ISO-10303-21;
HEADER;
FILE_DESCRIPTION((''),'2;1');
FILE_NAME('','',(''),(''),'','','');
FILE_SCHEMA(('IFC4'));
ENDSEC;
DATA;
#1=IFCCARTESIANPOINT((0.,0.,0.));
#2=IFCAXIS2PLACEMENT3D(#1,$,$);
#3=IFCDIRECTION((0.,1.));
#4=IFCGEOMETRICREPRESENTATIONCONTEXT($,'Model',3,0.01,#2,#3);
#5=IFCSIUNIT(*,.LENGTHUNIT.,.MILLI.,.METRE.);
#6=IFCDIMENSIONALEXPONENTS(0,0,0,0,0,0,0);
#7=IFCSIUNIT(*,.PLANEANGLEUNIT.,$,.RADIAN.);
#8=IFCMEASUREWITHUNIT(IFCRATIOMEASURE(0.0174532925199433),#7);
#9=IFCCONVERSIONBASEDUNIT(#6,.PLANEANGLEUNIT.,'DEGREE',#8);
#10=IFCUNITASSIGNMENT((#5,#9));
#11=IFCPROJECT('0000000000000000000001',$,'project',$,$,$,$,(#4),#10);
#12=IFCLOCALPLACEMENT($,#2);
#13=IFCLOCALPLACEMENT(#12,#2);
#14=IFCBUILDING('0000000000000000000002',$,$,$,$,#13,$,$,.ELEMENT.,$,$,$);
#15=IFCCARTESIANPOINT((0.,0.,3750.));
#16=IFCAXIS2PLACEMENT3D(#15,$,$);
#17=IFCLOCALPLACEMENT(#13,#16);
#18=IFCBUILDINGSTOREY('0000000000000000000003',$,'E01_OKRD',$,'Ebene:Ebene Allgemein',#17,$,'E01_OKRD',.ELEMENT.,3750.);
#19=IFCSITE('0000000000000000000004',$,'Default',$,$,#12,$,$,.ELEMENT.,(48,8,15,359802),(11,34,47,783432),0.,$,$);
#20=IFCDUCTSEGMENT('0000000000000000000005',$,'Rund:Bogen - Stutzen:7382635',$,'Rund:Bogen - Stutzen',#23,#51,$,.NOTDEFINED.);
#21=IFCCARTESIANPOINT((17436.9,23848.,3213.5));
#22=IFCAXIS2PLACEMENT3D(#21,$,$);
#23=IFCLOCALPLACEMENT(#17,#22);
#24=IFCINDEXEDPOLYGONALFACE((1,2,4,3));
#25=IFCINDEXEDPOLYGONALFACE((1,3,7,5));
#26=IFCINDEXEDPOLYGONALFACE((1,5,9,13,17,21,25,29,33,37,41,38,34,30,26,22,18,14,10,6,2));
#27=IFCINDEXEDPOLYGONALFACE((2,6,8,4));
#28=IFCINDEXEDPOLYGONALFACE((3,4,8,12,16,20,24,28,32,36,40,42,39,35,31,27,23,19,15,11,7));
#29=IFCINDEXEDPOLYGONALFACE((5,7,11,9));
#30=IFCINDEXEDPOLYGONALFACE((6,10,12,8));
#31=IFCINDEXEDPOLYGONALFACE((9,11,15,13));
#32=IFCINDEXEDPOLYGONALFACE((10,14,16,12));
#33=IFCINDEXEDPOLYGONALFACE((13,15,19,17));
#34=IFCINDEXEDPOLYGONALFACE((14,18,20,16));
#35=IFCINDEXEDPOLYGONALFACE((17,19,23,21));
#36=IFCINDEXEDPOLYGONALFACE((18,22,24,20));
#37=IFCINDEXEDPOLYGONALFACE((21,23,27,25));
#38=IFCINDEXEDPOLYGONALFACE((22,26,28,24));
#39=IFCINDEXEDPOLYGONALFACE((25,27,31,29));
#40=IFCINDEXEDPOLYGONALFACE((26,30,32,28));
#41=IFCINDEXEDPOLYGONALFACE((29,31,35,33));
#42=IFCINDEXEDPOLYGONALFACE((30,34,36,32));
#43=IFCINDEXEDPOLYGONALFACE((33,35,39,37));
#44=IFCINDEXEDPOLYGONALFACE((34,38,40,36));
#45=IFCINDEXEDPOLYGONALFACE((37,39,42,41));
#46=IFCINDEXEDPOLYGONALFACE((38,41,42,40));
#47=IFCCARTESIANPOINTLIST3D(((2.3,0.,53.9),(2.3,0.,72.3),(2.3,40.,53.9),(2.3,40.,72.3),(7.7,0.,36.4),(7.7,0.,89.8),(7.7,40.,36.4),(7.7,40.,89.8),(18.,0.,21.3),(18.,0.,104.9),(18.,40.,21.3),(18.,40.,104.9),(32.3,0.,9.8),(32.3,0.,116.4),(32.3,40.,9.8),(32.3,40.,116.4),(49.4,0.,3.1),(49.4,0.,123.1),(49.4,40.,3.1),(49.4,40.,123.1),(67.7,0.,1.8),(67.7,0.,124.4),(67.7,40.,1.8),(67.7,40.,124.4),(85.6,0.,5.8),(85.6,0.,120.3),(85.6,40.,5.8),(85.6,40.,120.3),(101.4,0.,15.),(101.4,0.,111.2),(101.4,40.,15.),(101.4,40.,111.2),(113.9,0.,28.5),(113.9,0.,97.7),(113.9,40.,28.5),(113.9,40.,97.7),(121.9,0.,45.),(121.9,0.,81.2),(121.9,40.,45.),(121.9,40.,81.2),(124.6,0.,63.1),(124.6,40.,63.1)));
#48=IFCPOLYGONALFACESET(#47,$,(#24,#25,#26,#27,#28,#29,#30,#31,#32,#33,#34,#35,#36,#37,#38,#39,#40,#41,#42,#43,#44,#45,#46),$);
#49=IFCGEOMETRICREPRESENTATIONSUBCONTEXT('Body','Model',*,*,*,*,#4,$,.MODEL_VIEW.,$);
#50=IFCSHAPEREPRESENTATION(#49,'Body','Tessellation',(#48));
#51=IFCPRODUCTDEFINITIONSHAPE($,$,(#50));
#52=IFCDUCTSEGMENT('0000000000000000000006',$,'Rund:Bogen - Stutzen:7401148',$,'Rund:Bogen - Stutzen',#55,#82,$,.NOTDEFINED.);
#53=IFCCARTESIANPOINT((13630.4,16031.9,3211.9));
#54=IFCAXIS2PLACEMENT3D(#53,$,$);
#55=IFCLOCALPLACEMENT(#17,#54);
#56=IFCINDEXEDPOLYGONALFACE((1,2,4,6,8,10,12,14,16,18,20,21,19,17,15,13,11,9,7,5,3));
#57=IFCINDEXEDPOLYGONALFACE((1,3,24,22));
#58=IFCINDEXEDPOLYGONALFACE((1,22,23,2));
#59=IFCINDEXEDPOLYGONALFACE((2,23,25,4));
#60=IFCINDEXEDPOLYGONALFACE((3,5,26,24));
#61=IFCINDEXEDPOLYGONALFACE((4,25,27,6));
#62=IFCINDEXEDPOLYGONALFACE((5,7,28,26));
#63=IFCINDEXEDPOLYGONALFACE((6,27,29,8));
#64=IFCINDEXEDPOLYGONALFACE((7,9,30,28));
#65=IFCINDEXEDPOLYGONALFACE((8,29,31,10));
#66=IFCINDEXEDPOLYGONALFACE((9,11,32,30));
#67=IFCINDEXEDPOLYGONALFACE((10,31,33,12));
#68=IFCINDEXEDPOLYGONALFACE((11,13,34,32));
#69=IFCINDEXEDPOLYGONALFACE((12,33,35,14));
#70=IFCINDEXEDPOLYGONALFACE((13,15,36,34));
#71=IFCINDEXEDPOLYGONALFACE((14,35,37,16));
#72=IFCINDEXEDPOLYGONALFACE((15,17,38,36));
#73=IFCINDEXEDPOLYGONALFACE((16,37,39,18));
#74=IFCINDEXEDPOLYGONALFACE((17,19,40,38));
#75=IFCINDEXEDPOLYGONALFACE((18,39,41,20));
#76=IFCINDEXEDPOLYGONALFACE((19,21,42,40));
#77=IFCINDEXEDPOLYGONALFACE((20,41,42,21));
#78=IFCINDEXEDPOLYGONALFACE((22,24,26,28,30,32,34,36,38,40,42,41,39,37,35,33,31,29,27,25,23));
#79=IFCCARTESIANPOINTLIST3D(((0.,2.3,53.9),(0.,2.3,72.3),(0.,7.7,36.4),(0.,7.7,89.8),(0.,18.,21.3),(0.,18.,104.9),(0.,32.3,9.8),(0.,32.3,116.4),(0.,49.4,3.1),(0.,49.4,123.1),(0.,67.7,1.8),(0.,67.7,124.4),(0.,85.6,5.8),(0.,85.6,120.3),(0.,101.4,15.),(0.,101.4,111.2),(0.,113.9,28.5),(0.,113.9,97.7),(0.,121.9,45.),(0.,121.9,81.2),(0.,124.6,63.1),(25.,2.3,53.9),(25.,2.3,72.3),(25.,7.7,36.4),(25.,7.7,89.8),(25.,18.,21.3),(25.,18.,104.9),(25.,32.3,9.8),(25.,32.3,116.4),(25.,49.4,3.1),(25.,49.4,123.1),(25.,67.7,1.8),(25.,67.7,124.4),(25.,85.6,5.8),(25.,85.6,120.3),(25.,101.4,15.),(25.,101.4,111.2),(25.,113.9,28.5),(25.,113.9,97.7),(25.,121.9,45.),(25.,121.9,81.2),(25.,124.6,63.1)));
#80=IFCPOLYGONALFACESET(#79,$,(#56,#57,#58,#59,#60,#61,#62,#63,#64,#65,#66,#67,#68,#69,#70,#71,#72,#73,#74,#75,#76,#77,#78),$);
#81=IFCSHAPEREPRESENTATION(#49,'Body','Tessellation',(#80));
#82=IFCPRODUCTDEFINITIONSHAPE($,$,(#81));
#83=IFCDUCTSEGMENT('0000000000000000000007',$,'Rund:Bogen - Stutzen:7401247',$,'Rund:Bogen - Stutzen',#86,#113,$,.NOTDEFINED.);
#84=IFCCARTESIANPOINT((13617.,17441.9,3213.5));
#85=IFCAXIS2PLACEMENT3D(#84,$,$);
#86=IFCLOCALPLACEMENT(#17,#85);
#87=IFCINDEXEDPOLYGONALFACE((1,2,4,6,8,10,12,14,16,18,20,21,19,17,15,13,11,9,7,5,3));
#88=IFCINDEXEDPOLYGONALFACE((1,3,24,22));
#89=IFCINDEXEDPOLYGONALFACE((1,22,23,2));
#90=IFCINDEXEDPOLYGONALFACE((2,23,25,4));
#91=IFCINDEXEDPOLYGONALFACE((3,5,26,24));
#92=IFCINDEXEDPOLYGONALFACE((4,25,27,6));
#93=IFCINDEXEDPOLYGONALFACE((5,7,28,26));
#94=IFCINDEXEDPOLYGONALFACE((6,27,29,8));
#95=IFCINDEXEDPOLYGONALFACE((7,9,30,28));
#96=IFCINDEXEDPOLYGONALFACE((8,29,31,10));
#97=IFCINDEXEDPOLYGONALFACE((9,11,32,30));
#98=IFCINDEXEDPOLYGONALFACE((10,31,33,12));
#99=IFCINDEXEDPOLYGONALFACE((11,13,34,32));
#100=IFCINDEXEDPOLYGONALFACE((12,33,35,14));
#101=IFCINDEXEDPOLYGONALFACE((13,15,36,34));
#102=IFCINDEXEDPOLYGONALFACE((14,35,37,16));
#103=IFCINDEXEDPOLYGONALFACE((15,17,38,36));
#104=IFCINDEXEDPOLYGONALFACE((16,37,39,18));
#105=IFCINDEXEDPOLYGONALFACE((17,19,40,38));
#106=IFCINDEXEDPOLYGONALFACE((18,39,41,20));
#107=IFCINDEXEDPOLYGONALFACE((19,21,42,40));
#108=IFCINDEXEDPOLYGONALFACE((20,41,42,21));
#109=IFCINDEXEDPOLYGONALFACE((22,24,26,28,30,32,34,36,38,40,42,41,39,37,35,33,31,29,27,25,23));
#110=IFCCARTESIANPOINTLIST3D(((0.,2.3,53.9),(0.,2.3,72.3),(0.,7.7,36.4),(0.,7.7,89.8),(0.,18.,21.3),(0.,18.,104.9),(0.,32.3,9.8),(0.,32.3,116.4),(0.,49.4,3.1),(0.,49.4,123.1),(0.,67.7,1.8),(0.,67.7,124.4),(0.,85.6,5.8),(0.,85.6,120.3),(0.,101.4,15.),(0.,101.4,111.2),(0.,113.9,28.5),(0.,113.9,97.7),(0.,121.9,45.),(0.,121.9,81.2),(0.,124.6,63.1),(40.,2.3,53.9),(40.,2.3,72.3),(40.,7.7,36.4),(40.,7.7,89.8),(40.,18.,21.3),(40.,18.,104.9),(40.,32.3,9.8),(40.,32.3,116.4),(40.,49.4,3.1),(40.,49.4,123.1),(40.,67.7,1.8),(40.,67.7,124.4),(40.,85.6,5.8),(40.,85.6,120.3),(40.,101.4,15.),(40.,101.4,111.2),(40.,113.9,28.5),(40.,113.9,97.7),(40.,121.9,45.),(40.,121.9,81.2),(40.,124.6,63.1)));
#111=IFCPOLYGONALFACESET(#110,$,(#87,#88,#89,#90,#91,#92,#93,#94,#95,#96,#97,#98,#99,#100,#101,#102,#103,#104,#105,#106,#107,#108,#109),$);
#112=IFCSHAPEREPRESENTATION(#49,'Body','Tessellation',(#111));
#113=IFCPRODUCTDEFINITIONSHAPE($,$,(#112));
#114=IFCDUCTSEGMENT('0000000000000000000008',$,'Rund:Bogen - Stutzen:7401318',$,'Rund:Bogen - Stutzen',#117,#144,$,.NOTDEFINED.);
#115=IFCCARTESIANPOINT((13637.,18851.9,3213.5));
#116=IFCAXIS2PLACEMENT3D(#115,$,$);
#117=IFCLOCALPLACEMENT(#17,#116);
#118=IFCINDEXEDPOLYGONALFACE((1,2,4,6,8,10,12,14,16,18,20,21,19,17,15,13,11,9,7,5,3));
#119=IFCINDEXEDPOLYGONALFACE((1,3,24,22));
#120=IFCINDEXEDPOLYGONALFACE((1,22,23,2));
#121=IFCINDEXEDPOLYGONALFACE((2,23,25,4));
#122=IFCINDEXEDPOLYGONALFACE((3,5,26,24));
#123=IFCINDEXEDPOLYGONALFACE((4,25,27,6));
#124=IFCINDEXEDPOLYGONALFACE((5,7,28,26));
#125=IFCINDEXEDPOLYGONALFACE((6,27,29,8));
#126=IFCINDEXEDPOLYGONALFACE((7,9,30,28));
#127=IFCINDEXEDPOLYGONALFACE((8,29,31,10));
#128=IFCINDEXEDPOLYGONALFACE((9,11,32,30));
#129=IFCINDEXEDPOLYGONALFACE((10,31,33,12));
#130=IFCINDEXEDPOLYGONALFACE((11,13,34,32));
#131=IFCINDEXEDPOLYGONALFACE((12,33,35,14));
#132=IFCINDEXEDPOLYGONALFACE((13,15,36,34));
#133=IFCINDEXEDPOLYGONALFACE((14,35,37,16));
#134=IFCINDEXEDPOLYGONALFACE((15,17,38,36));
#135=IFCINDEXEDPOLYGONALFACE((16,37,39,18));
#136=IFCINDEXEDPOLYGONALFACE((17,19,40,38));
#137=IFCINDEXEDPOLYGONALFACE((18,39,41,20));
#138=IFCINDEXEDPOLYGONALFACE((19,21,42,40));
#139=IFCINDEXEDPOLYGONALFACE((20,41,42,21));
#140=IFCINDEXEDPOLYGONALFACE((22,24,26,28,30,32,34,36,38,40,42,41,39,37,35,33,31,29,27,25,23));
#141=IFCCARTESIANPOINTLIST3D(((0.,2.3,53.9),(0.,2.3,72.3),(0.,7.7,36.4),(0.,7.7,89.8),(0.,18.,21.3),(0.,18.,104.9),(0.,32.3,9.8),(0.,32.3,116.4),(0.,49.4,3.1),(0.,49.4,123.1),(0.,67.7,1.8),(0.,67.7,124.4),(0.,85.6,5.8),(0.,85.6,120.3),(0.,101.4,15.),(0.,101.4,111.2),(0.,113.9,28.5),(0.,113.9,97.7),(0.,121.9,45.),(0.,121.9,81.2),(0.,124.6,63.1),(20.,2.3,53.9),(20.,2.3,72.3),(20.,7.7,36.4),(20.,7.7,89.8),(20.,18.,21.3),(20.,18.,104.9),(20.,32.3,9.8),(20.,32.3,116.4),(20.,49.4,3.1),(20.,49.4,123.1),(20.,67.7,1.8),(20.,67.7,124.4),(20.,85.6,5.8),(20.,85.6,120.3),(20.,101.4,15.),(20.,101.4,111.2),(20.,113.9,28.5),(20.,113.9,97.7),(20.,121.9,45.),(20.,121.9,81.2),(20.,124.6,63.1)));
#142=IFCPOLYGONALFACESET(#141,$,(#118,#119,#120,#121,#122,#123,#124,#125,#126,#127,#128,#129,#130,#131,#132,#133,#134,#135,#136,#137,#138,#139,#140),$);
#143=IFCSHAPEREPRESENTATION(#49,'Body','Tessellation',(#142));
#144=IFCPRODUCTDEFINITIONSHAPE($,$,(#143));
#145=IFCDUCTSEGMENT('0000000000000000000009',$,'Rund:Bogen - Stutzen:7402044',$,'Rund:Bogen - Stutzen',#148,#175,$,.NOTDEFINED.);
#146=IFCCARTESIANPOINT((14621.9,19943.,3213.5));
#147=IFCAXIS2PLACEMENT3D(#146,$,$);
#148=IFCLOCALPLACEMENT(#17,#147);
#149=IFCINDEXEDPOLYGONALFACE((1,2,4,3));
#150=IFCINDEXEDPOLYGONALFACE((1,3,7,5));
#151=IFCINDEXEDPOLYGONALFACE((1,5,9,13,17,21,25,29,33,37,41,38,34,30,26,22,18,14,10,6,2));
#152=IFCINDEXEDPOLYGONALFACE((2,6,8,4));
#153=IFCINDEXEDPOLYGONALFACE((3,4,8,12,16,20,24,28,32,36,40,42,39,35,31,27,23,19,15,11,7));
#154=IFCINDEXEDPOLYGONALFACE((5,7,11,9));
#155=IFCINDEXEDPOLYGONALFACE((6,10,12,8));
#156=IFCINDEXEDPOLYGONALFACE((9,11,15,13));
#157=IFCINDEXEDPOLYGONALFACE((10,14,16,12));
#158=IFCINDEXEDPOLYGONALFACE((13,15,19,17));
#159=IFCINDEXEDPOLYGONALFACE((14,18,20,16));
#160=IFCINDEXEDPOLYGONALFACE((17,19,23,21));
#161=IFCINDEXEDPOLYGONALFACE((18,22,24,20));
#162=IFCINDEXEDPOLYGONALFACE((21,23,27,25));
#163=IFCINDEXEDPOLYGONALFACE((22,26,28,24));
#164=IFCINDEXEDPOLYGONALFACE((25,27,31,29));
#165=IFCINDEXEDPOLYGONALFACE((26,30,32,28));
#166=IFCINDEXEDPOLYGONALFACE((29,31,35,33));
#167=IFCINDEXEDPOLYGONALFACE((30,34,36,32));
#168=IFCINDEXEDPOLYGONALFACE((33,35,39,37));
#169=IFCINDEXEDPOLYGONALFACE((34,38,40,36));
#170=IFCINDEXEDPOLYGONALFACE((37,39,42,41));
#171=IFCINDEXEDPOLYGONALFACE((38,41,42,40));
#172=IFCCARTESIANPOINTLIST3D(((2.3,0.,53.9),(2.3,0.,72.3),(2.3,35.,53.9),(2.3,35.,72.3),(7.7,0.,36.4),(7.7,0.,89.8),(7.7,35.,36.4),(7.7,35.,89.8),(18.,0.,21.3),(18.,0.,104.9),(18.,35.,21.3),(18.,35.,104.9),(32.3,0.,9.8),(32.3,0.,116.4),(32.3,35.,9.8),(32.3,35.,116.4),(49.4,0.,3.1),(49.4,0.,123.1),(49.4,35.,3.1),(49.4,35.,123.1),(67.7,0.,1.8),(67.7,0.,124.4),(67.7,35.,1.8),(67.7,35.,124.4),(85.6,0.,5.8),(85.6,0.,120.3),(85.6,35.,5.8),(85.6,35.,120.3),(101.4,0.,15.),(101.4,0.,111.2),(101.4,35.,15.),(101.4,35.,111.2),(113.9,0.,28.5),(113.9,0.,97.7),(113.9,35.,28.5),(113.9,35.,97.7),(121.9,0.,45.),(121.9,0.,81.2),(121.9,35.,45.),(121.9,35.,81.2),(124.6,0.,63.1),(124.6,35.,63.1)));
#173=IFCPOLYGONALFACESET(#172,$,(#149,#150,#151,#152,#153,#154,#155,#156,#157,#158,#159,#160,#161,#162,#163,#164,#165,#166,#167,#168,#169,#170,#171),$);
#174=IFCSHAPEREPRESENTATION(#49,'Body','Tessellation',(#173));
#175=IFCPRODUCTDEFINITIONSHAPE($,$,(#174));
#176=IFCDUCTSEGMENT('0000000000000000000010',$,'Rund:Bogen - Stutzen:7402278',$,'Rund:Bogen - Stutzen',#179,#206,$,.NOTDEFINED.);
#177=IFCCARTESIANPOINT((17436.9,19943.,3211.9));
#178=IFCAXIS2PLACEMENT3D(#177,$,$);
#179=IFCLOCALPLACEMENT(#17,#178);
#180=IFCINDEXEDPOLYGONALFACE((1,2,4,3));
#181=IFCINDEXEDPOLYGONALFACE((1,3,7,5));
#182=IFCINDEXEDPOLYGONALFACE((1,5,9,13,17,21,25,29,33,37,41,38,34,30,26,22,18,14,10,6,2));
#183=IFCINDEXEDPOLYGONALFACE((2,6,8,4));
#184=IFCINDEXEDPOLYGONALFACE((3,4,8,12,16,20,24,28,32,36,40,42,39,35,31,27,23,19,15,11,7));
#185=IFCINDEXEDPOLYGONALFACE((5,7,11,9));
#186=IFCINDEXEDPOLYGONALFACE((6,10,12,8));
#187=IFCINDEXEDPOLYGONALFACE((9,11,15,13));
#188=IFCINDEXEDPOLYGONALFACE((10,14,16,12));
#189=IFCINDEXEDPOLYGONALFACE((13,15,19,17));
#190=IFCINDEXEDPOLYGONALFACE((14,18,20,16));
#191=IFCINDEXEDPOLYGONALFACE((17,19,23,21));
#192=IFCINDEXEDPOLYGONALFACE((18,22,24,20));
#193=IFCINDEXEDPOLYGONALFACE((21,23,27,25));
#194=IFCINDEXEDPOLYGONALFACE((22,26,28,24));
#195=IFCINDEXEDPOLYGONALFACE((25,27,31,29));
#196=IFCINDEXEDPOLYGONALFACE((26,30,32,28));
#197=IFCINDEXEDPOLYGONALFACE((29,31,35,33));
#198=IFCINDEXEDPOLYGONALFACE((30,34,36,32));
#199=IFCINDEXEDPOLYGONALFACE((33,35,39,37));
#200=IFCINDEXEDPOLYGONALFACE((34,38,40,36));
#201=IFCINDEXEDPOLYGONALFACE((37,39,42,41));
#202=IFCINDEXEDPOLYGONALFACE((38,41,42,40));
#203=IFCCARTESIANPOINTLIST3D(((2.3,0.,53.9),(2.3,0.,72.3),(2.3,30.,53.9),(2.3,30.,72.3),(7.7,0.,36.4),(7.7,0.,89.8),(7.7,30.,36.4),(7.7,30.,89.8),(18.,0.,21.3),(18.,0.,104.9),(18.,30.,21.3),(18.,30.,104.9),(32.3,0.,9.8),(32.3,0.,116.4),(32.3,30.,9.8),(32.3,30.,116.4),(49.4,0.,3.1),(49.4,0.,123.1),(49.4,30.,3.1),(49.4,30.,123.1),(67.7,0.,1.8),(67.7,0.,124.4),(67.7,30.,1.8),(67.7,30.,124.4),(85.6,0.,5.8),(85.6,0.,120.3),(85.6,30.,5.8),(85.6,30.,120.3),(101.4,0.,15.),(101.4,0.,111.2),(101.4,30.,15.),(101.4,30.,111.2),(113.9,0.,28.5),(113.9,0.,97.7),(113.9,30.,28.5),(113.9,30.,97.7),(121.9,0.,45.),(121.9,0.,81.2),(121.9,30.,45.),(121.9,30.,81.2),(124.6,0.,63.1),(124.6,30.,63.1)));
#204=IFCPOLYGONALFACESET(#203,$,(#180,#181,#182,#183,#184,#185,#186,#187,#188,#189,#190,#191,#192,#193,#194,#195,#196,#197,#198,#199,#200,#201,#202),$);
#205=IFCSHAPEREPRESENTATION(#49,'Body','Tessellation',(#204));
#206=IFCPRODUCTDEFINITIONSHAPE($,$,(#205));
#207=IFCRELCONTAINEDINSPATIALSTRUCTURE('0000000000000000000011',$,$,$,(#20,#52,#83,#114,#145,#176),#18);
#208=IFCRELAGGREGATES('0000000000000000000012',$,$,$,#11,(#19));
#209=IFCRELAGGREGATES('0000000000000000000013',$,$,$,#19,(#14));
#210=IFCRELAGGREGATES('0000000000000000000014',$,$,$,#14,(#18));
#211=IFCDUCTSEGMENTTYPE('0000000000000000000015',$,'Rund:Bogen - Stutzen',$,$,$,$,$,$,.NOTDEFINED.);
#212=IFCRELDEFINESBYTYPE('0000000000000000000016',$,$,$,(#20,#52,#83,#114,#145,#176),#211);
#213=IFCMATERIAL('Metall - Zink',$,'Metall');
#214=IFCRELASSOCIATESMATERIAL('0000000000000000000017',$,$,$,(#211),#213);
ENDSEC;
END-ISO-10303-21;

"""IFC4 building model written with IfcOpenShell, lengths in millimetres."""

from ifc_helpers import new_model, entity, si_unit, converted_unit, direction, frame, frame_2d, origin, origin_2d_with_axis, place, context, subcontext, project, spatial, circle, extrude, material, type_object, element, save


model = new_model("IFC4")

# Units and contexts
model_context = context("Model", 3, precision=0.01, world=origin(), true_north=direction((0.0, 1.0)))
body_context = subcontext(model_context, "Body", "Model", "MODEL_VIEW")
ifc_project = project(units=[si_unit("LENGTHUNIT", "METRE", prefix="MILLI"), converted_unit("PLANEANGLEUNIT", "DEGREE", entity("IfcRatioMeasure", 0.0174532925199433), si_unit("PLANEANGLEUNIT", "RADIAN"), dimensions=[0, 0, 0, 0, 0, 0, 0])], contexts=[model_context])

# Site, building, storey
site_placement = place(None, origin())
site = spatial("IfcSite", under=ifc_project, at=site_placement, Name="Default", CompositionType="ELEMENT", RefLatitude=(48, 8, 15, 359802), RefLongitude=(11, 34, 47, 783432), RefElevation=0.0)
building_placement = place(site_placement, origin())
building = spatial("IfcBuilding", under=site, at=building_placement, CompositionType="ELEMENT")
storey_placement = place(building_placement, frame((0.0, 0.0, 3750.0)))
storey = spatial("IfcBuildingStorey", under=building, at=storey_placement, Name="E01_OKRD", ObjectType="Ebene:Ebene Allgemein", LongName="E01_OKRD", CompositionType="ELEMENT", Elevation=3750.0)

# Shared definitions
ifc_material_1 = material(Name="Metall - Zink", Category="Metall")

# Duct segments
duct_segment_type_1 = type_object("IfcDuctSegmentType", Name="Rund:Bogen - Stutzen", PredefinedType="NOTDEFINED", material=ifc_material_1)
duct_segment_1_placement = place(storey_placement, frame((17436.9, 23848.0, 3213.5)))
element("IfcDuctSegment", 1, at=duct_segment_1_placement, inside=storey, type_object=duct_segment_type_1, Name="Rund:Bogen - Stutzen:7382635", ObjectType="Rund:Bogen - Stutzen", PredefinedType="NOTDEFINED", context=body_context, shape_type="SweptSolid", body=[
    extrude(circle(Radius=61.5, at=origin_2d_with_axis()), frame((63.1, 0.0, 63.1), z_axis=(0.0, 1.0, 0.0), x_axis=(1.0, 0.0, 0.0)), (0.0, 0.0, 1.0), 40.0),
])
duct_segment_2_placement = place(storey_placement, frame((13630.4, 16031.9, 3211.9)))
element("IfcDuctSegment", 2, at=duct_segment_2_placement, inside=storey, type_object=duct_segment_type_1, Name="Rund:Bogen - Stutzen:7401148", ObjectType="Rund:Bogen - Stutzen", PredefinedType="NOTDEFINED", context=body_context, shape_type="SweptSolid", body=[
    extrude(circle(Radius=61.5, at=frame_2d((0.0, 0.0), x_axis=(1.0, 0.0))), frame((0.0, 63.1, 63.1), z_axis=(1.0, 0.0, 0.0), x_axis=(0.0, 1.0, 0.0)), (0.0, 0.0, 1.0), 25.0),
])
duct_segment_3_placement = place(storey_placement, frame((13617.0, 17441.9, 3213.5)))
element("IfcDuctSegment", 3, at=duct_segment_3_placement, inside=storey, type_object=duct_segment_type_1, Name="Rund:Bogen - Stutzen:7401247", ObjectType="Rund:Bogen - Stutzen", PredefinedType="NOTDEFINED", context=body_context, shape_type="SweptSolid", body=[
    extrude(circle(Radius=61.5, at=frame_2d((0.0, 0.0), x_axis=(1.0, 0.0))), frame((0.0, 63.1, 63.1), z_axis=(1.0, 0.0, 0.0), x_axis=(0.0, 1.0, 0.0)), (0.0, 0.0, 1.0), 40.0),
])
duct_segment_4_placement = place(storey_placement, frame((13637.0, 18851.9, 3213.5)))
element("IfcDuctSegment", 4, at=duct_segment_4_placement, inside=storey, type_object=duct_segment_type_1, Name="Rund:Bogen - Stutzen:7401318", ObjectType="Rund:Bogen - Stutzen", PredefinedType="NOTDEFINED", context=body_context, shape_type="SweptSolid", body=[
    extrude(circle(Radius=61.5, at=frame_2d((0.0, 0.0), x_axis=(1.0, 0.0))), frame((0.0, 63.1, 63.1), z_axis=(1.0, 0.0, 0.0), x_axis=(0.0, 1.0, 0.0)), (0.0, 0.0, 1.0), 20.0),
])
duct_segment_5_placement = place(storey_placement, frame((14621.9, 19943.0, 3213.5)))
element("IfcDuctSegment", 5, at=duct_segment_5_placement, inside=storey, type_object=duct_segment_type_1, Name="Rund:Bogen - Stutzen:7402044", ObjectType="Rund:Bogen - Stutzen", PredefinedType="NOTDEFINED", context=body_context, shape_type="SweptSolid", body=[
    extrude(circle(Radius=61.5, at=frame_2d((0.0, 0.0), x_axis=(1.0, 0.0))), frame((63.1, 0.0, 63.1), z_axis=(0.0, 1.0, 0.0), x_axis=(1.0, 0.0, 0.0)), (0.0, 0.0, 1.0), 35.0),
])
duct_segment_6_placement = place(storey_placement, frame((17436.9, 19943.0, 3211.9)))
element("IfcDuctSegment", 6, at=duct_segment_6_placement, inside=storey, type_object=duct_segment_type_1, Name="Rund:Bogen - Stutzen:7402278", ObjectType="Rund:Bogen - Stutzen", PredefinedType="NOTDEFINED", context=body_context, shape_type="SweptSolid", body=[
    extrude(circle(Radius=61.5, at=origin_2d_with_axis()), frame((63.1, 0.0, 63.1), z_axis=(0.0, 1.0, 0.0), x_axis=(1.0, 0.0, 0.0)), (0.0, 0.0, 1.0), 30.0),
])

save(model, "model.ifc")
